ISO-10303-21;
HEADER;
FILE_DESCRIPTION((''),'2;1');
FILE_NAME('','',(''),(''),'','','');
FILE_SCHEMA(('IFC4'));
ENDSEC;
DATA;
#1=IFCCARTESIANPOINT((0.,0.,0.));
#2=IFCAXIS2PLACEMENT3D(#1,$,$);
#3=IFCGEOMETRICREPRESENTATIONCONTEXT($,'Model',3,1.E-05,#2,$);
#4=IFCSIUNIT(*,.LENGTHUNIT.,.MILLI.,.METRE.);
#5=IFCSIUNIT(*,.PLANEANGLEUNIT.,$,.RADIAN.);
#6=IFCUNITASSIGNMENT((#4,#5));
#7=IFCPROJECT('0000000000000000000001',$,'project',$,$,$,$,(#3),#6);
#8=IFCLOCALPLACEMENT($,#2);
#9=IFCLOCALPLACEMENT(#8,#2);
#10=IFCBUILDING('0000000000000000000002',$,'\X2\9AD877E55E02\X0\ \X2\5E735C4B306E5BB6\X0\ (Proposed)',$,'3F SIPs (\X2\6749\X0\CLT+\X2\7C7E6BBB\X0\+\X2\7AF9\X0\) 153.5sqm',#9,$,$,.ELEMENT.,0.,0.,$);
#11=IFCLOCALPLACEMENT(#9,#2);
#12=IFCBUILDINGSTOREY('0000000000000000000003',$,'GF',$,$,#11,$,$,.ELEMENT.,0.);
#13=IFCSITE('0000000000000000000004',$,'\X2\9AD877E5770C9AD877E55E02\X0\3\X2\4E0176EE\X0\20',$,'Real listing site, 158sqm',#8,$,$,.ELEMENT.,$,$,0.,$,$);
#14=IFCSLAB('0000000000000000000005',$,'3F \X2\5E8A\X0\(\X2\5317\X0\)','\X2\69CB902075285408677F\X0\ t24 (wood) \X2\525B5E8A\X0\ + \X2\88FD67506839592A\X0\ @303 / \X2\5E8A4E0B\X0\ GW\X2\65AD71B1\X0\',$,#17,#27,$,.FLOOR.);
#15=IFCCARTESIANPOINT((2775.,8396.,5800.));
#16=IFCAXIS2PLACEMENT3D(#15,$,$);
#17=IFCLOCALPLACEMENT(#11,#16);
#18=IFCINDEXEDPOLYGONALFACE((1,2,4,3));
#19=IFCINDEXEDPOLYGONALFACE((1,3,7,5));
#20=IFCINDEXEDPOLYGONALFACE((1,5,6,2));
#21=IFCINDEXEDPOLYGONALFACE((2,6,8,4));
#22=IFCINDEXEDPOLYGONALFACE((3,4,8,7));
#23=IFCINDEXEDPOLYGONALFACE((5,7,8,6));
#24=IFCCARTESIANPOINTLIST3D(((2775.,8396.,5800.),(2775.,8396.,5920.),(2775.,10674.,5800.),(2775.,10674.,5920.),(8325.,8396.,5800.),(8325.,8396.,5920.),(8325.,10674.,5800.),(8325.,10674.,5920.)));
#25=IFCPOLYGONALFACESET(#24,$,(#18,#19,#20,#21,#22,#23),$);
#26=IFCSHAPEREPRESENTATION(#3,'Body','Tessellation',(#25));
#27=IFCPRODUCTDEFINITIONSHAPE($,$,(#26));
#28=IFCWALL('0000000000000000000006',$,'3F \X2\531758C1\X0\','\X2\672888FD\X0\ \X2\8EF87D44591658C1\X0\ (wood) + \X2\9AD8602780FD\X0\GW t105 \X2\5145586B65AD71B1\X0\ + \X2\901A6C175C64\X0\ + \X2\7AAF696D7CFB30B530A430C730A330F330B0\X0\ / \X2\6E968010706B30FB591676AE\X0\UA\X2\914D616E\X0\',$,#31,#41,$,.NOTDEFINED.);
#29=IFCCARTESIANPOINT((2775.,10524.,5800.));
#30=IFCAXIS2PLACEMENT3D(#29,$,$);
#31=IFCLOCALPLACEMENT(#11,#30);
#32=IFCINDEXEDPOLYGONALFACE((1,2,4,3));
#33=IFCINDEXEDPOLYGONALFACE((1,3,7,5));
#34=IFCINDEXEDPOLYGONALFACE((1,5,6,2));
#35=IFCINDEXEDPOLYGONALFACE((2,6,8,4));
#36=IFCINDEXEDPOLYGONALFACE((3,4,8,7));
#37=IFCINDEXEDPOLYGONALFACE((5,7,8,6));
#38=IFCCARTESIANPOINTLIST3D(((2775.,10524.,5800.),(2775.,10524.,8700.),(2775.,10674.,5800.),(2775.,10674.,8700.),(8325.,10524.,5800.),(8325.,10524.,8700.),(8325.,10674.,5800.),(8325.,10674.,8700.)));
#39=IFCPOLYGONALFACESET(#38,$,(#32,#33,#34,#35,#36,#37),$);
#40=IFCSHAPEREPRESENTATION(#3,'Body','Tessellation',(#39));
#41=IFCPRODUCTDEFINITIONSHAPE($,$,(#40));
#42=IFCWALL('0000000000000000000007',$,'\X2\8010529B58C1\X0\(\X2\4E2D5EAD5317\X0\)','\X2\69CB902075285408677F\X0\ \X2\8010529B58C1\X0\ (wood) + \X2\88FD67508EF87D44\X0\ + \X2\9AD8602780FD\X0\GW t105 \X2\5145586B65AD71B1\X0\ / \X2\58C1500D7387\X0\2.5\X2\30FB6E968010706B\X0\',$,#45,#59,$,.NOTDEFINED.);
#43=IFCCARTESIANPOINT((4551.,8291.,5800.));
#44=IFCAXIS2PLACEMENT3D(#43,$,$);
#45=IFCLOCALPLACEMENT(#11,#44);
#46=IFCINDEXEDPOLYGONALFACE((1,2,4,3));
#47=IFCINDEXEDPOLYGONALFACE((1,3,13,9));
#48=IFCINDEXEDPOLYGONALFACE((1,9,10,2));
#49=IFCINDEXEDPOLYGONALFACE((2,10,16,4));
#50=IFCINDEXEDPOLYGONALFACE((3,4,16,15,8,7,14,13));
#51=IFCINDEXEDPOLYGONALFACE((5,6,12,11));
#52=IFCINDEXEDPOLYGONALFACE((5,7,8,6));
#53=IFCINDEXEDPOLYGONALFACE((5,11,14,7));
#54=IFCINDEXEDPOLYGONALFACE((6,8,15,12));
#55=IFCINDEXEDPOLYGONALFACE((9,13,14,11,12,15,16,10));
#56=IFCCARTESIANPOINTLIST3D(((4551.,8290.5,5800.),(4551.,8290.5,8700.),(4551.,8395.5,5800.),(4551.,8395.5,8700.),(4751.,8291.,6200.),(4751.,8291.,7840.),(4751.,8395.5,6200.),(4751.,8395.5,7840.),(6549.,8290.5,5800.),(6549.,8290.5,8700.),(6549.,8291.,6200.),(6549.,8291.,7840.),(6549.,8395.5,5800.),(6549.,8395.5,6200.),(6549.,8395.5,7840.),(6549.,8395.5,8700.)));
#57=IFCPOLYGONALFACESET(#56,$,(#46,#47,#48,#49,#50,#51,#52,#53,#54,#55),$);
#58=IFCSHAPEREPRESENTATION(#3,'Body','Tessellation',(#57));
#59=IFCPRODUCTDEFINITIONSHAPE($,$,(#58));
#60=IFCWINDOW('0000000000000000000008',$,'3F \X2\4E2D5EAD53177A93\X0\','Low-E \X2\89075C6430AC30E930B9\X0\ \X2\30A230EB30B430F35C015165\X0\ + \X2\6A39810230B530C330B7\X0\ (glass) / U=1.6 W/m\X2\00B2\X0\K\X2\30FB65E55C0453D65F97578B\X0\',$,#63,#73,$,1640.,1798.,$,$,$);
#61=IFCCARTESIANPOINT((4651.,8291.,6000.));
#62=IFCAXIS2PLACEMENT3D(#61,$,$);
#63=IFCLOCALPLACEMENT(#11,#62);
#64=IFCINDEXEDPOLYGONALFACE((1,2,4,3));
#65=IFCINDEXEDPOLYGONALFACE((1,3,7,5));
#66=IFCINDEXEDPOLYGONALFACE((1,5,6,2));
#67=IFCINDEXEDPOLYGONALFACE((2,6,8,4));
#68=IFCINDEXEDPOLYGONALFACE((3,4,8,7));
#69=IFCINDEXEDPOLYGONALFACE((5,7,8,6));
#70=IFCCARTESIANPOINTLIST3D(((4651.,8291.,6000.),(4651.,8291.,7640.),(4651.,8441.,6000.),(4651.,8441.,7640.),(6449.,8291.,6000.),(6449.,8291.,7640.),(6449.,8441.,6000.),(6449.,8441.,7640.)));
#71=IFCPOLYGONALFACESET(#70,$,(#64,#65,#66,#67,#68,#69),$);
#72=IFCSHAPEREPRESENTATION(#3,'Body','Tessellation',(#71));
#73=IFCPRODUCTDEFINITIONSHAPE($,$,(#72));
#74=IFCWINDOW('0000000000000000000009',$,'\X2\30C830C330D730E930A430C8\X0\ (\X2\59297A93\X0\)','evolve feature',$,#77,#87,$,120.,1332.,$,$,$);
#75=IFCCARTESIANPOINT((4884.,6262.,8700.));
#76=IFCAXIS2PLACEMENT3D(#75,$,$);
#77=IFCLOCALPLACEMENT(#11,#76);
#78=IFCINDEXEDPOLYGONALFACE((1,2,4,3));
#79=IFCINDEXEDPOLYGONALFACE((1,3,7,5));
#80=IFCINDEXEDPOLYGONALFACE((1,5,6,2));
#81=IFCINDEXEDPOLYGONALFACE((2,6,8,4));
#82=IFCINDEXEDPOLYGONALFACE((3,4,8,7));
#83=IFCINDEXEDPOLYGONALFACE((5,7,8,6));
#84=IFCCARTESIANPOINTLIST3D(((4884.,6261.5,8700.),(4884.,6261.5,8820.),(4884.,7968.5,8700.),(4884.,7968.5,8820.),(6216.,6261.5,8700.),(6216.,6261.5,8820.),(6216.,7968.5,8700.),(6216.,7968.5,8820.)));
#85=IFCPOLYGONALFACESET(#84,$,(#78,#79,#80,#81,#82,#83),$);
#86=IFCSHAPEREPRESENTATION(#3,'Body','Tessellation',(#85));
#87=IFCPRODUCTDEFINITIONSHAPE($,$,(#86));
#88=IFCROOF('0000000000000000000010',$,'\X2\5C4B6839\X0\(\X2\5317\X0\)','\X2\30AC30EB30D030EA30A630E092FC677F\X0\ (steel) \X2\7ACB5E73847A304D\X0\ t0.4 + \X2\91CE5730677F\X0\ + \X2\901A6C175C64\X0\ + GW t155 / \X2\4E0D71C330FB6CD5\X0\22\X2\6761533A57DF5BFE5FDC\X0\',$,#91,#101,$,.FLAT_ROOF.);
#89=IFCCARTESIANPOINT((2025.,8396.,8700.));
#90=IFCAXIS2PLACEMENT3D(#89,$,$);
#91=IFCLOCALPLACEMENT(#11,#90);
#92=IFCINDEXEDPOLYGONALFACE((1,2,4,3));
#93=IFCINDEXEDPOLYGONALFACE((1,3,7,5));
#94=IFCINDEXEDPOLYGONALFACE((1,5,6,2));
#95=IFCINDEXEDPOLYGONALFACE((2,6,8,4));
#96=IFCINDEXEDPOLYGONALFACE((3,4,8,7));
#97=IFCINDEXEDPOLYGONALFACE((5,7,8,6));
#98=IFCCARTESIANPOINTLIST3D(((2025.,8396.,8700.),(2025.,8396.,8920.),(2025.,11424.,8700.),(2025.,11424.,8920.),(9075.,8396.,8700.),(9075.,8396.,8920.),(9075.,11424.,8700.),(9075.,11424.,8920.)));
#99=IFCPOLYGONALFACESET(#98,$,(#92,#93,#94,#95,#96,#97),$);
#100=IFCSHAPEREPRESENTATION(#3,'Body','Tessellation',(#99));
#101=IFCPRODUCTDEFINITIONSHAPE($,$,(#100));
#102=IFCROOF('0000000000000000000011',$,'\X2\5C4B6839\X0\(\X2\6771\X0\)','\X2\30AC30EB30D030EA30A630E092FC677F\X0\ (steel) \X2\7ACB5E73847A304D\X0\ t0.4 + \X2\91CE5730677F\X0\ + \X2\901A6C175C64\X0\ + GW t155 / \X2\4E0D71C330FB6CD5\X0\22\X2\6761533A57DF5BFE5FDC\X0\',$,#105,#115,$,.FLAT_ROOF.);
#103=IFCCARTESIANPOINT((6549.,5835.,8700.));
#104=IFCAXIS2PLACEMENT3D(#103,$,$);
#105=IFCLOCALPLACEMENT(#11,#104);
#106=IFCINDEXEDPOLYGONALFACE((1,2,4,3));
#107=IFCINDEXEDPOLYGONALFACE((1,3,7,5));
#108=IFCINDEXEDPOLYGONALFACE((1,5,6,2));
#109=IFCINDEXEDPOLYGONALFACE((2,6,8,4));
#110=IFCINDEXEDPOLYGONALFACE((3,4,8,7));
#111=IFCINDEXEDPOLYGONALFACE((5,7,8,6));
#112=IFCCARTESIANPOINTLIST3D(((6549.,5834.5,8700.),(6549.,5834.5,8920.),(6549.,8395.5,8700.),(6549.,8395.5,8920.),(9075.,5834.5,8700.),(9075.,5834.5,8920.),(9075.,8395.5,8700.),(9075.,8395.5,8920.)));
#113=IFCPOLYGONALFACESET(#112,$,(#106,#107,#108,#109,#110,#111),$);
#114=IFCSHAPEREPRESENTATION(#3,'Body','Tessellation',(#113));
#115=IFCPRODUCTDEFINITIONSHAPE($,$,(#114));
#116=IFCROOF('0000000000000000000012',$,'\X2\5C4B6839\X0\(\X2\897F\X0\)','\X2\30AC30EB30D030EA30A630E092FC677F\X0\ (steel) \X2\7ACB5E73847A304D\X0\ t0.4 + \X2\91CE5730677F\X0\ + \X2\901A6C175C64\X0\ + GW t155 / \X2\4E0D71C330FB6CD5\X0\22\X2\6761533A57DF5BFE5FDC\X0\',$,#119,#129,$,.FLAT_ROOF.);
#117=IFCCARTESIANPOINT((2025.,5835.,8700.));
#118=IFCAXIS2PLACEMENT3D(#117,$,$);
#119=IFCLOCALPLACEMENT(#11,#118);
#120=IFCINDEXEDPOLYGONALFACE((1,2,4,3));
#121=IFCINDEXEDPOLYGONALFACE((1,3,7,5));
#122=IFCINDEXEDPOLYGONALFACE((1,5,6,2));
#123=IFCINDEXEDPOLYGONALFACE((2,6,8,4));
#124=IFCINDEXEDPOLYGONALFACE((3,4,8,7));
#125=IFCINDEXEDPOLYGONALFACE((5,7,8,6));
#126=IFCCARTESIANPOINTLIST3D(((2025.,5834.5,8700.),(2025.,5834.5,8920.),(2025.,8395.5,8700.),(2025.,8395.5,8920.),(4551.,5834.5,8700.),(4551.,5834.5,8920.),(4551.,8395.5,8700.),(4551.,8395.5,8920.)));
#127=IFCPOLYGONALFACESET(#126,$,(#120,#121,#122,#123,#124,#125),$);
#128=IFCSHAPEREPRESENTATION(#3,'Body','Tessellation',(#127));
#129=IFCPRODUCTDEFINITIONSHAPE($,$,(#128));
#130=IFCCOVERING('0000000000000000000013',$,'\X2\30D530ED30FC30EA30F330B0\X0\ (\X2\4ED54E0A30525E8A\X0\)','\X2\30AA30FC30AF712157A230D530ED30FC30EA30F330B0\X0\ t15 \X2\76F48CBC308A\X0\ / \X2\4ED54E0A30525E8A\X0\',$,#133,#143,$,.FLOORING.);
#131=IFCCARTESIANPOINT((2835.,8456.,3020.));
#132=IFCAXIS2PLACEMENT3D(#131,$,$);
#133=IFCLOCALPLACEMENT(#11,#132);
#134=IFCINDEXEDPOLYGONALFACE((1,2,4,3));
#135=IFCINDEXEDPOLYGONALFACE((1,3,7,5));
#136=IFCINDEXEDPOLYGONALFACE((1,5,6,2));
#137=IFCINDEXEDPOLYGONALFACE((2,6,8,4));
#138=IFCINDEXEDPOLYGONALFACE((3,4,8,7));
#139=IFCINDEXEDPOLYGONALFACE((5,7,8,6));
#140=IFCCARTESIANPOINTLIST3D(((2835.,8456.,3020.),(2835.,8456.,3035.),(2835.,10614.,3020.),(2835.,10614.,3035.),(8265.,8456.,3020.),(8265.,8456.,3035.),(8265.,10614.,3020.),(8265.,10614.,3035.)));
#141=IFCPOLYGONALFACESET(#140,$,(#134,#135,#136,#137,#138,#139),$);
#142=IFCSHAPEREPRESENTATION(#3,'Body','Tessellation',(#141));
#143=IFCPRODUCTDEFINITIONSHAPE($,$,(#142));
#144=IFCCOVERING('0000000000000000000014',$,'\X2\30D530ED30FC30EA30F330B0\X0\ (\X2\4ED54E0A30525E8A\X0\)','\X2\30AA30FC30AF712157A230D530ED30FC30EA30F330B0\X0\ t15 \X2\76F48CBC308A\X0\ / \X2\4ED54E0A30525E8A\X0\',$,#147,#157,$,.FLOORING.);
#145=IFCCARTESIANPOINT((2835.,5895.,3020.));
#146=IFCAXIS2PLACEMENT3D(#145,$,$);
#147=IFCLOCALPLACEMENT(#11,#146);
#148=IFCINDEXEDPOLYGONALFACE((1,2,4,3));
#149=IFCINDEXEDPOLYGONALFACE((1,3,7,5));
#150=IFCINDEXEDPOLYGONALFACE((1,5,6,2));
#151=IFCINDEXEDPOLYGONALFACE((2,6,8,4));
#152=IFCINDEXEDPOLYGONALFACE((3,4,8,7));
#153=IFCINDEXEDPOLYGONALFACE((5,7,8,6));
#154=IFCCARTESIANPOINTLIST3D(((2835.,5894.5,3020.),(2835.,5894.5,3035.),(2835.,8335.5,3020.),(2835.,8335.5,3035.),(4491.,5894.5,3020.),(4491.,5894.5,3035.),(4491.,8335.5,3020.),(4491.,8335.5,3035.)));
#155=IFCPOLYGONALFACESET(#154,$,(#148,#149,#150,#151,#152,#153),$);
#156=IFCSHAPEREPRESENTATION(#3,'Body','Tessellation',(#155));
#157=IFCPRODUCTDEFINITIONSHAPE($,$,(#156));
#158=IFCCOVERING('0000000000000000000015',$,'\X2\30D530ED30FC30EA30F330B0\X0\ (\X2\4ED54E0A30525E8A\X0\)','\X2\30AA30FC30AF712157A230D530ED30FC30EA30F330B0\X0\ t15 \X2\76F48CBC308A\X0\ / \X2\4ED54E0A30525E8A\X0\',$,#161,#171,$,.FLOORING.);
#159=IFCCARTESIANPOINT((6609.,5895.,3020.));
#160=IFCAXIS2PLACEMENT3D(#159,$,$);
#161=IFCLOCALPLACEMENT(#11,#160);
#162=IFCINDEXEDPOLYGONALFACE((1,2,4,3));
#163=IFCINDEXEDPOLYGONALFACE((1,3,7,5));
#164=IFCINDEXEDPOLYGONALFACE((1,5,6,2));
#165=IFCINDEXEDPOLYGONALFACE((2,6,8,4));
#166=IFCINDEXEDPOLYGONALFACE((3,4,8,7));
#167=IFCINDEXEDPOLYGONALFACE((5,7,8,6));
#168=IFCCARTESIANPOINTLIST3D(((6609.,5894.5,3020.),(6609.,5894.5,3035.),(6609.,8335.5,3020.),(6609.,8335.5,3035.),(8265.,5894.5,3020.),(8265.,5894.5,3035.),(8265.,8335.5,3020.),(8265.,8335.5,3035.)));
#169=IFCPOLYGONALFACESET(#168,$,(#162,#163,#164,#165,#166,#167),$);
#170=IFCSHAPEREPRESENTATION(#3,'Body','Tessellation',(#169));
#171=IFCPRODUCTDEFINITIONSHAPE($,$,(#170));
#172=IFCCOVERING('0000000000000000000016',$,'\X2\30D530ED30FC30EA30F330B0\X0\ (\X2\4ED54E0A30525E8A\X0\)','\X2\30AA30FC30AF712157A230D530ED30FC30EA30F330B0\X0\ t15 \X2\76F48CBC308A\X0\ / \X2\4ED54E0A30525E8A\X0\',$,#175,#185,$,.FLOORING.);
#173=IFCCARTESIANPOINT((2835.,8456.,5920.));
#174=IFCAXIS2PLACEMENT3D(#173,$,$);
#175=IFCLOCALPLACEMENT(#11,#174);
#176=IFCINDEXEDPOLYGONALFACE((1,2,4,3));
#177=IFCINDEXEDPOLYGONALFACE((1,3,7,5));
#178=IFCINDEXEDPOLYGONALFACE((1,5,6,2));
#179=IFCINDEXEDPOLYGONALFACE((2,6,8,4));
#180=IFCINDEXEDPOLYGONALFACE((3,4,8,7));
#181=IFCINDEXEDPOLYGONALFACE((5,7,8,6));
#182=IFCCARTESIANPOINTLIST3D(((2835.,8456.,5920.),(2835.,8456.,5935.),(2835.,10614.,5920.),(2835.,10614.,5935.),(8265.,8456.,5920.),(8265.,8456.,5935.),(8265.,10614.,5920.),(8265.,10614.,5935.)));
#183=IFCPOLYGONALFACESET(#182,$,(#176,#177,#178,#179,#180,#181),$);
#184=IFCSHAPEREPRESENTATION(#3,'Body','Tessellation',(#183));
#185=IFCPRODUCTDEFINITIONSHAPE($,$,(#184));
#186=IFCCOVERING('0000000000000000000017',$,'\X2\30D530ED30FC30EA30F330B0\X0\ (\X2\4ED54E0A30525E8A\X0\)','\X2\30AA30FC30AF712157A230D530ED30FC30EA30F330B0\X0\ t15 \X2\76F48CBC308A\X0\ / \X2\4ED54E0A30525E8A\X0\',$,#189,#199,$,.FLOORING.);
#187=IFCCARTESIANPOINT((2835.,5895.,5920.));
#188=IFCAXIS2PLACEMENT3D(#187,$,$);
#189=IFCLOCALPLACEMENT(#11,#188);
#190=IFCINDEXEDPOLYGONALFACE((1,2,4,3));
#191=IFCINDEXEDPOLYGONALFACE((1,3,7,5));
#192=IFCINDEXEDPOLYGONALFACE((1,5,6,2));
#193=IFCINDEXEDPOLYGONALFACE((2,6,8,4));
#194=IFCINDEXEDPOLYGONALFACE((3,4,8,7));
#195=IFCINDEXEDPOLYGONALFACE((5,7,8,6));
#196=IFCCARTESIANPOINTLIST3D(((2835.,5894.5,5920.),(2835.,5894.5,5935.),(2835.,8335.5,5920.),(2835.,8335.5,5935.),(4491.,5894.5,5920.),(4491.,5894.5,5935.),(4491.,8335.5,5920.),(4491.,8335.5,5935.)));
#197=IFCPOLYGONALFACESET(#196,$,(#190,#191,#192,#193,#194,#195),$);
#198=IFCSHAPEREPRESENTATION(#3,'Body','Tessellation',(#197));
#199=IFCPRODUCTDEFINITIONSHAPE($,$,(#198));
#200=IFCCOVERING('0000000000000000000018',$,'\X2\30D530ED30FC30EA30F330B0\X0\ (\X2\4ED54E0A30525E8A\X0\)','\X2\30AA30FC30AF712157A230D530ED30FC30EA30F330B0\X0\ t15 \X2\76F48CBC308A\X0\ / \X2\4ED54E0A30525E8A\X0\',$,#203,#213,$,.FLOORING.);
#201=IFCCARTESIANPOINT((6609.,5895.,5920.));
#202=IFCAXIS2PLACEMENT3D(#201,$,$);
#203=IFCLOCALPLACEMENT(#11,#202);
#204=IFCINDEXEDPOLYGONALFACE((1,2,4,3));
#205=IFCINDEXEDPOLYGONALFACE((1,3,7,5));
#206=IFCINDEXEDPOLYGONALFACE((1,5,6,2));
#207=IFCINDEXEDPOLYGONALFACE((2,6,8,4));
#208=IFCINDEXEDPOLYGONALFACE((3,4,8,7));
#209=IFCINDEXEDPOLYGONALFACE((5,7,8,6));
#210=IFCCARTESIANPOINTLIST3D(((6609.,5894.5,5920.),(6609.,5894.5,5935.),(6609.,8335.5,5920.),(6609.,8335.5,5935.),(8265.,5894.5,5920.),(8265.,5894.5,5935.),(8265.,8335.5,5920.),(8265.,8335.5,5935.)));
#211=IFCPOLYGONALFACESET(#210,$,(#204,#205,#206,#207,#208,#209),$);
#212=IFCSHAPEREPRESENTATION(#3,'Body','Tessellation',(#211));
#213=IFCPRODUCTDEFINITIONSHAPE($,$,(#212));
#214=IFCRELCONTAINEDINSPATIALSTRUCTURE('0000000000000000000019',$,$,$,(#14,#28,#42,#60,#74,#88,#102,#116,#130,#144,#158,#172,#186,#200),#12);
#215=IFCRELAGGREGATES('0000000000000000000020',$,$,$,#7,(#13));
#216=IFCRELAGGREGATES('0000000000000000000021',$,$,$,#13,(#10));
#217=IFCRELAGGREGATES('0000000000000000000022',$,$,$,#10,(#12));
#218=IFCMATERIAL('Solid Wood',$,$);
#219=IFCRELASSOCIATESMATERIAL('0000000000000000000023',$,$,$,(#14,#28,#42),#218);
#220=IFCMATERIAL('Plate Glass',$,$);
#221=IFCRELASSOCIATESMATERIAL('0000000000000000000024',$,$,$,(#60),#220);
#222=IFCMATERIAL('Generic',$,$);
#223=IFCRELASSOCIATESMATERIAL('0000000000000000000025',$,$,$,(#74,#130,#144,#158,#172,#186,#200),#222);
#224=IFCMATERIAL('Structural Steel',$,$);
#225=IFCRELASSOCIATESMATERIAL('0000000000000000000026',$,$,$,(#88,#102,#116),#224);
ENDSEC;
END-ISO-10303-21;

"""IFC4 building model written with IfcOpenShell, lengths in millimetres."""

from ifc_helpers import new_model, si_unit, frame, frame_2d, origin, place, context, project, spatial, rectangle, extrude, material, element, fill, save


model = new_model("IFC4")

# Units and contexts
model_context = context("Model", 3, precision=1e-05, world=origin())
ifc_project = project(units=[si_unit("LENGTHUNIT", "METRE", prefix="MILLI"), si_unit("PLANEANGLEUNIT", "RADIAN")], contexts=[model_context])

# Site, building, storey
site_placement = place(None, origin())
site = spatial("IfcSite", under=ifc_project, at=site_placement, Name="高知県高知市3丁目20", ObjectType="Real listing site, 158sqm", CompositionType="ELEMENT", RefElevation=0.0)
building_placement = place(site_placement, origin())
building = spatial("IfcBuilding", under=site, at=building_placement, Name="高知市 平屋の家 (Proposed)", ObjectType="3F SIPs (杉CLT+籾殻+竹) 153.5sqm", CompositionType="ELEMENT", ElevationOfRefHeight=0.0, ElevationOfTerrain=0.0)
storey_placement = place(building_placement, origin())
storey = spatial("IfcBuildingStorey", under=building, at=storey_placement, Name="GF", CompositionType="ELEMENT", Elevation=0.0)

# Slab
ifc_material_1 = material(Name="Solid Wood")
slab_placement = place(storey_placement, frame((2775.0, 8396.0, 5800.0)))
element("IfcSlab", 1, at=slab_placement, inside=storey, material=ifc_material_1, Name="3F 床(北)", Description="構造用合板 t24 (wood) 剛床 + 製材根太 @303 / 床下 GW断熱", PredefinedType="FLOOR", context=model_context, shape_type="SweptSolid", body=[
    extrude(rectangle(XDim=5550.0, YDim=2278.0, at=frame_2d((2775.0, 1139.0))), frame((2775.0, 8396.0, 5800.0)), (0.0, 0.0, 1.0), 120.0),
])

# Wall
wall_1_placement = place(storey_placement, frame((2775.0, 10524.0, 5800.0)))
element("IfcWall", 2, at=wall_1_placement, inside=storey, material=ifc_material_1, Name="3F 北壁", Description="木製 軸組外壁 (wood) + 高性能GW t105 充填断熱 + 通気層 + 窯業系サイディング / 準耐火・外皮UA配慮", PredefinedType="NOTDEFINED", context=model_context, shape_type="SweptSolid", body=[
    extrude(rectangle(XDim=5550.0, YDim=150.0, at=frame_2d((2775.0, 75.0))), frame((2775.0, 10524.0, 5800.0)), (0.0, 0.0, 1.0), 2900.0),
])

# Wall, opening, window
wall_2_placement = place(storey_placement, frame((4551.0, 8291.0, 5800.0)))
wall_2 = element("IfcWall", 3, at=wall_2_placement, inside=storey, material=ifc_material_1, Name="耐力壁(中庭北)", Description="構造用合板 耐力壁 (wood) + 製材軸組 + 高性能GW t105 充填断熱 / 壁倍率2.5・準耐火", PredefinedType="NOTDEFINED", context=model_context, shape_type="SweptSolid", body=[
    extrude(rectangle(XDim=1998.0, YDim=105.0, at=frame_2d((999.0, 52.0))), frame((4551.0, 8291.0, 5800.0)), (0.0, 0.0, 1.0), 2900.0),
])
opening_placement = place(storey_placement, frame((4651.0, 8291.0, 6000.0)))
opening = element("IfcOpeningElement", 4, at=opening_placement, cuts=wall_2, PredefinedType="NOTDEFINED", context=model_context, shape_type="SweptSolid", body=[
    extrude(rectangle(XDim=1798.0, YDim=150.0, at=frame_2d((899.0, 75.0))), frame((4651.0, 8291.0, 6000.0)), (0.0, 0.0, 1.0), 1640.0),
])
ifc_material_2 = material(Name="Plate Glass")
window_1_placement = place(storey_placement, frame((4651.0, 8291.0, 6000.0)))
window_1 = element("IfcWindow", 5, at=window_1_placement, inside=storey, material=ifc_material_2, Name="3F 中庭北窓", Description="Low-E 複層ガラス アルゴン封入 + 樹脂サッシ (glass) / U=1.6 W/m²K・日射取得型", OverallHeight=1640.0, OverallWidth=1798.0, context=model_context, shape_type="SweptSolid", body=[
    extrude(rectangle(XDim=1798.0, YDim=150.0, at=frame_2d((899.0, 75.0))), frame((4651.0, 8291.0, 6000.0)), (0.0, 0.0, 1.0), 1640.0),
])
fill(opening, window_1)

# Window
ifc_material_3 = material(Name="Generic")
window_2_placement = place(storey_placement, frame((4884.0, 6262.0, 8700.0)))
element("IfcWindow", 6, at=window_2_placement, inside=storey, material=ifc_material_3, Name="トップライト (天窓)", Description="evolve feature", OverallHeight=120.0, OverallWidth=1332.0, context=model_context, shape_type="SweptSolid", body=[
    extrude(rectangle(XDim=1332.0, YDim=1707.0, at=frame_2d((666.0, 853.0))), frame((4884.0, 6262.0, 8700.0)), (0.0, 0.0, 1.0), 120.0),
])

# Roofs
ifc_material_4 = material(Name="Structural Steel")
roof_1_placement = place(storey_placement, frame((2025.0, 8396.0, 8700.0)))
element("IfcRoof", 7, at=roof_1_placement, inside=storey, material=ifc_material_4, Name="屋根(北)", Description="ガルバリウム鋼板 (steel) 立平葺き t0.4 + 野地板 + 通気層 + GW t155 / 不燃・法22条区域対応", PredefinedType="FLAT_ROOF", context=model_context, shape_type="SweptSolid", body=[
    extrude(rectangle(XDim=7050.0, YDim=3028.0, at=frame_2d((3525.0, 1514.0))), frame((2025.0, 8396.0, 8700.0)), (0.0, 0.0, 1.0), 220.0),
])
roof_2_placement = place(storey_placement, frame((6549.0, 5835.0, 8700.0)))
element("IfcRoof", 8, at=roof_2_placement, inside=storey, material=ifc_material_4, Name="屋根(東)", Description="ガルバリウム鋼板 (steel) 立平葺き t0.4 + 野地板 + 通気層 + GW t155 / 不燃・法22条区域対応", PredefinedType="FLAT_ROOF", context=model_context, shape_type="SweptSolid", body=[
    extrude(rectangle(XDim=2526.0, YDim=2561.0, at=frame_2d((1263.0, 1280.0))), frame((6549.0, 5835.0, 8700.0)), (0.0, 0.0, 1.0), 220.0),
])
roof_3_placement = place(storey_placement, frame((2025.0, 5835.0, 8700.0)))
element("IfcRoof", 9, at=roof_3_placement, inside=storey, material=ifc_material_4, Name="屋根(西)", Description="ガルバリウム鋼板 (steel) 立平葺き t0.4 + 野地板 + 通気層 + GW t155 / 不燃・法22条区域対応", PredefinedType="FLAT_ROOF", context=model_context, shape_type="SweptSolid", body=[
    extrude(rectangle(XDim=2526.0, YDim=2561.0, at=frame_2d((1263.0, 1280.0))), frame((2025.0, 5835.0, 8700.0)), (0.0, 0.0, 1.0), 220.0),
])

# Coverings
covering_1_placement = place(storey_placement, frame((2835.0, 8456.0, 3020.0)))
element("IfcCovering", 10, at=covering_1_placement, inside=storey, material=ifc_material_3, Name="フローリング (仕上げ床)", Description="オーク無垢フローリング t15 直貼り / 仕上げ床", PredefinedType="FLOORING", context=model_context, shape_type="SweptSolid", body=[
    extrude(rectangle(XDim=5430.0, YDim=2158.0, at=frame_2d((2715.0, 1079.0))), frame((2835.0, 8456.0, 3020.0)), (0.0, 0.0, 1.0), 15.0),
])
covering_2_placement = place(storey_placement, frame((2835.0, 5895.0, 3020.0)))
element("IfcCovering", 11, at=covering_2_placement, inside=storey, material=ifc_material_3, Name="フローリング (仕上げ床)", Description="オーク無垢フローリング t15 直貼り / 仕上げ床", PredefinedType="FLOORING", context=model_context, shape_type="SweptSolid", body=[
    extrude(rectangle(XDim=1656.0, YDim=2441.0, at=frame_2d((828.0, 1220.0))), frame((2835.0, 5895.0, 3020.0)), (0.0, 0.0, 1.0), 15.0),
])
covering_3_placement = place(storey_placement, frame((6609.0, 5895.0, 3020.0)))
element("IfcCovering", 12, at=covering_3_placement, inside=storey, material=ifc_material_3, Name="フローリング (仕上げ床)", Description="オーク無垢フローリング t15 直貼り / 仕上げ床", PredefinedType="FLOORING", context=model_context, shape_type="SweptSolid", body=[
    extrude(rectangle(XDim=1656.0, YDim=2441.0, at=frame_2d((828.0, 1220.0))), frame((6609.0, 5895.0, 3020.0)), (0.0, 0.0, 1.0), 15.0),
])
covering_4_placement = place(storey_placement, frame((2835.0, 8456.0, 5920.0)))
element("IfcCovering", 13, at=covering_4_placement, inside=storey, material=ifc_material_3, Name="フローリング (仕上げ床)", Description="オーク無垢フローリング t15 直貼り / 仕上げ床", PredefinedType="FLOORING", context=model_context, shape_type="SweptSolid", body=[
    extrude(rectangle(XDim=5430.0, YDim=2158.0, at=frame_2d((2715.0, 1079.0))), frame((2835.0, 8456.0, 5920.0)), (0.0, 0.0, 1.0), 15.0),
])
covering_5_placement = place(storey_placement, frame((2835.0, 5895.0, 5920.0)))
element("IfcCovering", 14, at=covering_5_placement, inside=storey, material=ifc_material_3, Name="フローリング (仕上げ床)", Description="オーク無垢フローリング t15 直貼り / 仕上げ床", PredefinedType="FLOORING", context=model_context, shape_type="SweptSolid", body=[
    extrude(rectangle(XDim=1656.0, YDim=2441.0, at=frame_2d((828.0, 1220.0))), frame((2835.0, 5895.0, 5920.0)), (0.0, 0.0, 1.0), 15.0),
])
covering_6_placement = place(storey_placement, frame((6609.0, 5895.0, 5920.0)))
element("IfcCovering", 15, at=covering_6_placement, inside=storey, material=ifc_material_3, Name="フローリング (仕上げ床)", Description="オーク無垢フローリング t15 直貼り / 仕上げ床", PredefinedType="FLOORING", context=model_context, shape_type="SweptSolid", body=[
    extrude(rectangle(XDim=1656.0, YDim=2441.0, at=frame_2d((828.0, 1220.0))), frame((6609.0, 5895.0, 5920.0)), (0.0, 0.0, 1.0), 15.0),
])

save(model, "model.ifc")
